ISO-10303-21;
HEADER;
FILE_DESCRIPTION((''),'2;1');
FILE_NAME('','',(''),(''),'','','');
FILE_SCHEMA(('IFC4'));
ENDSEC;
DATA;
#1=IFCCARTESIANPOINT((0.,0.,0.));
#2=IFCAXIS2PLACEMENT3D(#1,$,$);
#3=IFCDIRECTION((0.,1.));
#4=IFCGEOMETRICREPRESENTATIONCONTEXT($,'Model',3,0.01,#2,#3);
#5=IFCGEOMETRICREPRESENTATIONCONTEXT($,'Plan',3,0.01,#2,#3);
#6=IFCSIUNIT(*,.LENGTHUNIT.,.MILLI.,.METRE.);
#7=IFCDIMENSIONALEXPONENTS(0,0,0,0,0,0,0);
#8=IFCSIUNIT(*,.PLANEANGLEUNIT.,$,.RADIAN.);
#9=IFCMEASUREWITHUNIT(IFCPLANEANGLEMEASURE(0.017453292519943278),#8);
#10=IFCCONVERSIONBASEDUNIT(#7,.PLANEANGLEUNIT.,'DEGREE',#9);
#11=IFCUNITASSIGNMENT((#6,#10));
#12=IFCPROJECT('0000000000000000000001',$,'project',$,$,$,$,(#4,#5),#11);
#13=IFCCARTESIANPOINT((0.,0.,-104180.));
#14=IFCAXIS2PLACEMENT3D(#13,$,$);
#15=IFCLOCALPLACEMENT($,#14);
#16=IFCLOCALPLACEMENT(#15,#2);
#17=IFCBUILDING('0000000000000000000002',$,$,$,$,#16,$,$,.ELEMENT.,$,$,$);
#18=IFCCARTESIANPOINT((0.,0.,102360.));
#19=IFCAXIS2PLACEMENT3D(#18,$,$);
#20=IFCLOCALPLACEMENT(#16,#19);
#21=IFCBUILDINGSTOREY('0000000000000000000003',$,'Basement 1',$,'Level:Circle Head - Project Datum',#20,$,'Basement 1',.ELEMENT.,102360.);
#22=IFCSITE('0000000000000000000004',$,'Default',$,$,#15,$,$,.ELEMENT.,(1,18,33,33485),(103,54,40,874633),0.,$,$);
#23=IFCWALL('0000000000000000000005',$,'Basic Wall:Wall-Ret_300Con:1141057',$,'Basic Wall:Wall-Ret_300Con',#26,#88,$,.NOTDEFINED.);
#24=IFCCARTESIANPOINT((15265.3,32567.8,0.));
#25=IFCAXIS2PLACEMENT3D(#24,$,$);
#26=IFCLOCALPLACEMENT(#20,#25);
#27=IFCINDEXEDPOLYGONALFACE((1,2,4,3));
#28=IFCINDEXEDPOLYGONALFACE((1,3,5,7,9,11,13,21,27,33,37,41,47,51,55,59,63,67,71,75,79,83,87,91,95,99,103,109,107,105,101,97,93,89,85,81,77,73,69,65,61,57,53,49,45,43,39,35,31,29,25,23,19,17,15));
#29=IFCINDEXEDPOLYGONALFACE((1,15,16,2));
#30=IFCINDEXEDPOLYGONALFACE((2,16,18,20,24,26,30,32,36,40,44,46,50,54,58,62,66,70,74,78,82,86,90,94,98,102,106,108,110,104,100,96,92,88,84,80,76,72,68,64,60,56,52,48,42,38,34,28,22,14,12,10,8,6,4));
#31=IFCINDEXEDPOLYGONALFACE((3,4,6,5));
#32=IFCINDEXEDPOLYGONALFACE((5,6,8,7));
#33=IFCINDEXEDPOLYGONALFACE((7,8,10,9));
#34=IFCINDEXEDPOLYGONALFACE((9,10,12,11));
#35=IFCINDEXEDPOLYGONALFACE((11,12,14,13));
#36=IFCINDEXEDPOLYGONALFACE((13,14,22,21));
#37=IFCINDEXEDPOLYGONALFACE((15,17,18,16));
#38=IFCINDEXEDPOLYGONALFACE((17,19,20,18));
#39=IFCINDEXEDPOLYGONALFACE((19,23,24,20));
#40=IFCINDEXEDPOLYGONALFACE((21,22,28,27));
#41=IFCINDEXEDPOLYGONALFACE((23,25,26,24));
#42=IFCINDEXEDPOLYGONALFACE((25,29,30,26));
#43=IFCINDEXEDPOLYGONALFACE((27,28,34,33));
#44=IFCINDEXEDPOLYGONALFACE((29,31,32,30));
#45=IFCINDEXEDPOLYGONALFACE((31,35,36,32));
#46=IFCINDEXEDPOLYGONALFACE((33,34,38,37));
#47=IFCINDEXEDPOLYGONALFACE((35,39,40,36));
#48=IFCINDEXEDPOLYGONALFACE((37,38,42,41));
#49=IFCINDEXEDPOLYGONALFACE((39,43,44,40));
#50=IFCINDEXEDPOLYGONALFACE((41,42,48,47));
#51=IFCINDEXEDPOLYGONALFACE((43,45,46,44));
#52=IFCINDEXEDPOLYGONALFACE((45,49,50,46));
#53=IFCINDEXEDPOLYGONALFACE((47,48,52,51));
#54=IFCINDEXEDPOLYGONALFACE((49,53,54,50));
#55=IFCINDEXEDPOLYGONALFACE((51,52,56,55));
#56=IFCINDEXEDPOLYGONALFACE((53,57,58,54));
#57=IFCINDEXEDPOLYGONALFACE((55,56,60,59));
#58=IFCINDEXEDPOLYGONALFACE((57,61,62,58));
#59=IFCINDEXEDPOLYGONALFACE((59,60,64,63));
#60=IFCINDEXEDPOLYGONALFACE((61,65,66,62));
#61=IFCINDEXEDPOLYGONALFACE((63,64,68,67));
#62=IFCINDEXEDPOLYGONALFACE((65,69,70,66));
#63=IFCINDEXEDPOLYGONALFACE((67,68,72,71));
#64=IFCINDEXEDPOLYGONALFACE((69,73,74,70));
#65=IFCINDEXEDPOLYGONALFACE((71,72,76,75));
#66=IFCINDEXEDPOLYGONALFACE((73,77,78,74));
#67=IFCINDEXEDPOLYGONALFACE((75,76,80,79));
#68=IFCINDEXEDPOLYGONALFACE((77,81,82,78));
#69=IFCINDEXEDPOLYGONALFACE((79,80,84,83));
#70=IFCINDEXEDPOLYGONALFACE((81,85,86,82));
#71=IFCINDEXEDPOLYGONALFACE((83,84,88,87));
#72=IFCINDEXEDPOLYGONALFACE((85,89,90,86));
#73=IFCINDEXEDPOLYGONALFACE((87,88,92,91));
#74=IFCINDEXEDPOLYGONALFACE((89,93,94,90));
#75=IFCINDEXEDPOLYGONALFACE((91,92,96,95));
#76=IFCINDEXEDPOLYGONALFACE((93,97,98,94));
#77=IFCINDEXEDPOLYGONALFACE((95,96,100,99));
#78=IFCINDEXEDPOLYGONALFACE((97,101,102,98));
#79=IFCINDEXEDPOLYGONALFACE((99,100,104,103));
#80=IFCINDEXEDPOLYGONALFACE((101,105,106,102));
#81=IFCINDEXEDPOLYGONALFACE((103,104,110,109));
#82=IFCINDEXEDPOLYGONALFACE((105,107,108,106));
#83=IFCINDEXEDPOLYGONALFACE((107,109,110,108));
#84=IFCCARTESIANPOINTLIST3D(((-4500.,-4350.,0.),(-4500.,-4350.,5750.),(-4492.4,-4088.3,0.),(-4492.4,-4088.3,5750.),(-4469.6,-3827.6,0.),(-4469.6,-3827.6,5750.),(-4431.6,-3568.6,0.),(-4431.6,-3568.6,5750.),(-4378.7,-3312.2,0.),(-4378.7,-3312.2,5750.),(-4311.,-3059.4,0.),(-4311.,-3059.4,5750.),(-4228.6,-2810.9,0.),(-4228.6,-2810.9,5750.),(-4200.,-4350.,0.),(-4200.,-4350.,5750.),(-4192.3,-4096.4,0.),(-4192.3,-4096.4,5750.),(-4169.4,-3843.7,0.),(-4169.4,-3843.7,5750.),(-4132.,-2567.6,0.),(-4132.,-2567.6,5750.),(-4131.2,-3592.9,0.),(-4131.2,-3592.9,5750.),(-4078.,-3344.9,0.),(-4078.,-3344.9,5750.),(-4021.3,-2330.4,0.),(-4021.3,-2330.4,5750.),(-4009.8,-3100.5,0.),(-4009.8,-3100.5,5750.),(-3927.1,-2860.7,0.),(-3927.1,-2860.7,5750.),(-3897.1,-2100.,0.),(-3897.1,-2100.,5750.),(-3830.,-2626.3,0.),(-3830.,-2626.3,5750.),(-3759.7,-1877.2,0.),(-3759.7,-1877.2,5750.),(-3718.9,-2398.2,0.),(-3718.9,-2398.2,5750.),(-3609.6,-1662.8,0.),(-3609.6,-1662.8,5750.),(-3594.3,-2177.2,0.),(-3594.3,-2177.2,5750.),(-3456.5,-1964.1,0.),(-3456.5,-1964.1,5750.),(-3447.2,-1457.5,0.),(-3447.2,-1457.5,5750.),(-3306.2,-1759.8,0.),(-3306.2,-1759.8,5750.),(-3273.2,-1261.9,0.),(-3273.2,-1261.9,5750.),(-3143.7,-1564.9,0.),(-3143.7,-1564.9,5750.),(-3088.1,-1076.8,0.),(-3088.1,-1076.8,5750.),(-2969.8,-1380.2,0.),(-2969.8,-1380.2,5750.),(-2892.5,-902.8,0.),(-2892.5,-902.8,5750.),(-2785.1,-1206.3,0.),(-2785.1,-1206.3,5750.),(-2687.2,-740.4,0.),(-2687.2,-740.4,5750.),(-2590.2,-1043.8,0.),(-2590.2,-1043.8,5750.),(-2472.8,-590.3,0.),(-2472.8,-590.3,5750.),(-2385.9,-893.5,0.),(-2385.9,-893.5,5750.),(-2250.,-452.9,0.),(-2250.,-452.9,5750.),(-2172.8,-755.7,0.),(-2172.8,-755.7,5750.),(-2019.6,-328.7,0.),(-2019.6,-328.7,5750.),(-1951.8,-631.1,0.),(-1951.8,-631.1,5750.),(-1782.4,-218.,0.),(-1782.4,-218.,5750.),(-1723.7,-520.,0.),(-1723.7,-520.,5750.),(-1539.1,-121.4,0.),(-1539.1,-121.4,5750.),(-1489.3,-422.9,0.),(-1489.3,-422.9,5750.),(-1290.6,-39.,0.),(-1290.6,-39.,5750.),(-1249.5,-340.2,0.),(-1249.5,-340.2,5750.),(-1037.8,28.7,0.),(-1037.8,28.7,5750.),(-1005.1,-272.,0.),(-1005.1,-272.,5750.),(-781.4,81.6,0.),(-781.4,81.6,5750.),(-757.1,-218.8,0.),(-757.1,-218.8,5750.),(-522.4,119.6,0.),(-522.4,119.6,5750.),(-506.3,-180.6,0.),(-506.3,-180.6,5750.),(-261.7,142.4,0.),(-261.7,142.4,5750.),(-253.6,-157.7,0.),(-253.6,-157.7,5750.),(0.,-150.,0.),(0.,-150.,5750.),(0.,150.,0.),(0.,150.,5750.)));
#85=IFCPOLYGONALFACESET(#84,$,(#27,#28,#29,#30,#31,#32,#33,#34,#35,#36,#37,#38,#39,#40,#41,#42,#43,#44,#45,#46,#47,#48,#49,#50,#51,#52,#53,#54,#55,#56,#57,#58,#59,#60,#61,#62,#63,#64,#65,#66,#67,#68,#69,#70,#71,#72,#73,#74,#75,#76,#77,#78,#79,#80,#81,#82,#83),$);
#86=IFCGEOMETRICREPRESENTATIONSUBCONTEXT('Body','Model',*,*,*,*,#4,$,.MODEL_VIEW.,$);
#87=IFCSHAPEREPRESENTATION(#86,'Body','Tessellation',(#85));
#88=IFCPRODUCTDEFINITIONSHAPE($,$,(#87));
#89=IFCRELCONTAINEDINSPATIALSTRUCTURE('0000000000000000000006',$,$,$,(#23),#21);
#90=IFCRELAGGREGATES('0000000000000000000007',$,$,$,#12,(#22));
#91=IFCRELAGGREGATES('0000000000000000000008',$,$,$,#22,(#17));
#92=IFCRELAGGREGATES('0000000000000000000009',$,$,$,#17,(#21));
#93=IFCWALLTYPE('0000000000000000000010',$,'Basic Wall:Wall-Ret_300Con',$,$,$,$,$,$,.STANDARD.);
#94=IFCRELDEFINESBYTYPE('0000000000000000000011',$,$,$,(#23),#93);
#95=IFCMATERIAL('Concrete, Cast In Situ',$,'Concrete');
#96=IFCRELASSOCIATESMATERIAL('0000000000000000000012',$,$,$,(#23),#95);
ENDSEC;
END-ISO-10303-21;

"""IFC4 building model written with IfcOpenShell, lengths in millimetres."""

from ifc_helpers import new_model, entity, si_unit, converted_unit, direction, frame, origin, place, context, subcontext, project, spatial, line, arc, indexed_curve, outline, extrude, material, type_object, element, save


model = new_model("IFC4")

# Units and contexts
model_context = context("Model", 3, precision=0.01, world=origin(), true_north=direction((0.0, 1.0)))
plan_context = context("Plan", 3, precision=0.01, world=origin(), true_north=direction((0.0, 1.0)))
body_context = subcontext(model_context, "Body", "Model", "MODEL_VIEW")
ifc_project = project(units=[si_unit("LENGTHUNIT", "METRE", prefix="MILLI"), converted_unit("PLANEANGLEUNIT", "DEGREE", entity("IfcPlaneAngleMeasure", 0.017453292519943278), si_unit("PLANEANGLEUNIT", "RADIAN"), dimensions=[0, 0, 0, 0, 0, 0, 0])], contexts=[model_context, plan_context])

# Site, building, storey
site_placement = place(None, frame((0.0, 0.0, -104180.0)))
site = spatial("IfcSite", under=ifc_project, at=site_placement, Name="Default", CompositionType="ELEMENT", RefLatitude=(1, 18, 33, 33485), RefLongitude=(103, 54, 40, 874633), RefElevation=0.0)
building_placement = place(site_placement, origin())
building = spatial("IfcBuilding", under=site, at=building_placement, CompositionType="ELEMENT")
storey_placement = place(building_placement, frame((0.0, 0.0, 102360.0)))
storey = spatial("IfcBuildingStorey", under=building, at=storey_placement, Name="Basement 1", ObjectType="Level:Circle Head - Project Datum", LongName="Basement 1", CompositionType="ELEMENT", Elevation=102360.0)

# Shared definitions
ifc_material_1 = material(Name="Concrete, Cast In Situ", Category="Concrete")
wall_type = type_object("IfcWallType", Name="Basic Wall:Wall-Ret_300Con", PredefinedType="STANDARD")

# Wall
wall_1_placement = place(storey_placement, frame((15265.3, 32567.8, 0.0)))
element("IfcWall", 1, at=wall_1_placement, inside=storey, type_object=wall_type, material=ifc_material_1, Name="Basic Wall:Wall-Ret_300Con:1141057", ObjectType="Basic Wall:Wall-Ret_300Con", PredefinedType="NOTDEFINED", context=body_context, shape_type="SweptSolid", body=[
    extrude(outline(indexed_curve([(-4200.0, -4350.0), (-2969.8, -1380.2), (0.0, -150.0), (0.0, 150.0), (-3182.0, -1168.0), (-4500.0, -4350.0)], segments=[arc(1, 2, 3), line(3, 4), arc(4, 5, 6), line(6, 1)], self_intersect=False)), origin(), (0.0, 0.0, 1.0), 5750.0),
])

save(model, "model.ifc")
